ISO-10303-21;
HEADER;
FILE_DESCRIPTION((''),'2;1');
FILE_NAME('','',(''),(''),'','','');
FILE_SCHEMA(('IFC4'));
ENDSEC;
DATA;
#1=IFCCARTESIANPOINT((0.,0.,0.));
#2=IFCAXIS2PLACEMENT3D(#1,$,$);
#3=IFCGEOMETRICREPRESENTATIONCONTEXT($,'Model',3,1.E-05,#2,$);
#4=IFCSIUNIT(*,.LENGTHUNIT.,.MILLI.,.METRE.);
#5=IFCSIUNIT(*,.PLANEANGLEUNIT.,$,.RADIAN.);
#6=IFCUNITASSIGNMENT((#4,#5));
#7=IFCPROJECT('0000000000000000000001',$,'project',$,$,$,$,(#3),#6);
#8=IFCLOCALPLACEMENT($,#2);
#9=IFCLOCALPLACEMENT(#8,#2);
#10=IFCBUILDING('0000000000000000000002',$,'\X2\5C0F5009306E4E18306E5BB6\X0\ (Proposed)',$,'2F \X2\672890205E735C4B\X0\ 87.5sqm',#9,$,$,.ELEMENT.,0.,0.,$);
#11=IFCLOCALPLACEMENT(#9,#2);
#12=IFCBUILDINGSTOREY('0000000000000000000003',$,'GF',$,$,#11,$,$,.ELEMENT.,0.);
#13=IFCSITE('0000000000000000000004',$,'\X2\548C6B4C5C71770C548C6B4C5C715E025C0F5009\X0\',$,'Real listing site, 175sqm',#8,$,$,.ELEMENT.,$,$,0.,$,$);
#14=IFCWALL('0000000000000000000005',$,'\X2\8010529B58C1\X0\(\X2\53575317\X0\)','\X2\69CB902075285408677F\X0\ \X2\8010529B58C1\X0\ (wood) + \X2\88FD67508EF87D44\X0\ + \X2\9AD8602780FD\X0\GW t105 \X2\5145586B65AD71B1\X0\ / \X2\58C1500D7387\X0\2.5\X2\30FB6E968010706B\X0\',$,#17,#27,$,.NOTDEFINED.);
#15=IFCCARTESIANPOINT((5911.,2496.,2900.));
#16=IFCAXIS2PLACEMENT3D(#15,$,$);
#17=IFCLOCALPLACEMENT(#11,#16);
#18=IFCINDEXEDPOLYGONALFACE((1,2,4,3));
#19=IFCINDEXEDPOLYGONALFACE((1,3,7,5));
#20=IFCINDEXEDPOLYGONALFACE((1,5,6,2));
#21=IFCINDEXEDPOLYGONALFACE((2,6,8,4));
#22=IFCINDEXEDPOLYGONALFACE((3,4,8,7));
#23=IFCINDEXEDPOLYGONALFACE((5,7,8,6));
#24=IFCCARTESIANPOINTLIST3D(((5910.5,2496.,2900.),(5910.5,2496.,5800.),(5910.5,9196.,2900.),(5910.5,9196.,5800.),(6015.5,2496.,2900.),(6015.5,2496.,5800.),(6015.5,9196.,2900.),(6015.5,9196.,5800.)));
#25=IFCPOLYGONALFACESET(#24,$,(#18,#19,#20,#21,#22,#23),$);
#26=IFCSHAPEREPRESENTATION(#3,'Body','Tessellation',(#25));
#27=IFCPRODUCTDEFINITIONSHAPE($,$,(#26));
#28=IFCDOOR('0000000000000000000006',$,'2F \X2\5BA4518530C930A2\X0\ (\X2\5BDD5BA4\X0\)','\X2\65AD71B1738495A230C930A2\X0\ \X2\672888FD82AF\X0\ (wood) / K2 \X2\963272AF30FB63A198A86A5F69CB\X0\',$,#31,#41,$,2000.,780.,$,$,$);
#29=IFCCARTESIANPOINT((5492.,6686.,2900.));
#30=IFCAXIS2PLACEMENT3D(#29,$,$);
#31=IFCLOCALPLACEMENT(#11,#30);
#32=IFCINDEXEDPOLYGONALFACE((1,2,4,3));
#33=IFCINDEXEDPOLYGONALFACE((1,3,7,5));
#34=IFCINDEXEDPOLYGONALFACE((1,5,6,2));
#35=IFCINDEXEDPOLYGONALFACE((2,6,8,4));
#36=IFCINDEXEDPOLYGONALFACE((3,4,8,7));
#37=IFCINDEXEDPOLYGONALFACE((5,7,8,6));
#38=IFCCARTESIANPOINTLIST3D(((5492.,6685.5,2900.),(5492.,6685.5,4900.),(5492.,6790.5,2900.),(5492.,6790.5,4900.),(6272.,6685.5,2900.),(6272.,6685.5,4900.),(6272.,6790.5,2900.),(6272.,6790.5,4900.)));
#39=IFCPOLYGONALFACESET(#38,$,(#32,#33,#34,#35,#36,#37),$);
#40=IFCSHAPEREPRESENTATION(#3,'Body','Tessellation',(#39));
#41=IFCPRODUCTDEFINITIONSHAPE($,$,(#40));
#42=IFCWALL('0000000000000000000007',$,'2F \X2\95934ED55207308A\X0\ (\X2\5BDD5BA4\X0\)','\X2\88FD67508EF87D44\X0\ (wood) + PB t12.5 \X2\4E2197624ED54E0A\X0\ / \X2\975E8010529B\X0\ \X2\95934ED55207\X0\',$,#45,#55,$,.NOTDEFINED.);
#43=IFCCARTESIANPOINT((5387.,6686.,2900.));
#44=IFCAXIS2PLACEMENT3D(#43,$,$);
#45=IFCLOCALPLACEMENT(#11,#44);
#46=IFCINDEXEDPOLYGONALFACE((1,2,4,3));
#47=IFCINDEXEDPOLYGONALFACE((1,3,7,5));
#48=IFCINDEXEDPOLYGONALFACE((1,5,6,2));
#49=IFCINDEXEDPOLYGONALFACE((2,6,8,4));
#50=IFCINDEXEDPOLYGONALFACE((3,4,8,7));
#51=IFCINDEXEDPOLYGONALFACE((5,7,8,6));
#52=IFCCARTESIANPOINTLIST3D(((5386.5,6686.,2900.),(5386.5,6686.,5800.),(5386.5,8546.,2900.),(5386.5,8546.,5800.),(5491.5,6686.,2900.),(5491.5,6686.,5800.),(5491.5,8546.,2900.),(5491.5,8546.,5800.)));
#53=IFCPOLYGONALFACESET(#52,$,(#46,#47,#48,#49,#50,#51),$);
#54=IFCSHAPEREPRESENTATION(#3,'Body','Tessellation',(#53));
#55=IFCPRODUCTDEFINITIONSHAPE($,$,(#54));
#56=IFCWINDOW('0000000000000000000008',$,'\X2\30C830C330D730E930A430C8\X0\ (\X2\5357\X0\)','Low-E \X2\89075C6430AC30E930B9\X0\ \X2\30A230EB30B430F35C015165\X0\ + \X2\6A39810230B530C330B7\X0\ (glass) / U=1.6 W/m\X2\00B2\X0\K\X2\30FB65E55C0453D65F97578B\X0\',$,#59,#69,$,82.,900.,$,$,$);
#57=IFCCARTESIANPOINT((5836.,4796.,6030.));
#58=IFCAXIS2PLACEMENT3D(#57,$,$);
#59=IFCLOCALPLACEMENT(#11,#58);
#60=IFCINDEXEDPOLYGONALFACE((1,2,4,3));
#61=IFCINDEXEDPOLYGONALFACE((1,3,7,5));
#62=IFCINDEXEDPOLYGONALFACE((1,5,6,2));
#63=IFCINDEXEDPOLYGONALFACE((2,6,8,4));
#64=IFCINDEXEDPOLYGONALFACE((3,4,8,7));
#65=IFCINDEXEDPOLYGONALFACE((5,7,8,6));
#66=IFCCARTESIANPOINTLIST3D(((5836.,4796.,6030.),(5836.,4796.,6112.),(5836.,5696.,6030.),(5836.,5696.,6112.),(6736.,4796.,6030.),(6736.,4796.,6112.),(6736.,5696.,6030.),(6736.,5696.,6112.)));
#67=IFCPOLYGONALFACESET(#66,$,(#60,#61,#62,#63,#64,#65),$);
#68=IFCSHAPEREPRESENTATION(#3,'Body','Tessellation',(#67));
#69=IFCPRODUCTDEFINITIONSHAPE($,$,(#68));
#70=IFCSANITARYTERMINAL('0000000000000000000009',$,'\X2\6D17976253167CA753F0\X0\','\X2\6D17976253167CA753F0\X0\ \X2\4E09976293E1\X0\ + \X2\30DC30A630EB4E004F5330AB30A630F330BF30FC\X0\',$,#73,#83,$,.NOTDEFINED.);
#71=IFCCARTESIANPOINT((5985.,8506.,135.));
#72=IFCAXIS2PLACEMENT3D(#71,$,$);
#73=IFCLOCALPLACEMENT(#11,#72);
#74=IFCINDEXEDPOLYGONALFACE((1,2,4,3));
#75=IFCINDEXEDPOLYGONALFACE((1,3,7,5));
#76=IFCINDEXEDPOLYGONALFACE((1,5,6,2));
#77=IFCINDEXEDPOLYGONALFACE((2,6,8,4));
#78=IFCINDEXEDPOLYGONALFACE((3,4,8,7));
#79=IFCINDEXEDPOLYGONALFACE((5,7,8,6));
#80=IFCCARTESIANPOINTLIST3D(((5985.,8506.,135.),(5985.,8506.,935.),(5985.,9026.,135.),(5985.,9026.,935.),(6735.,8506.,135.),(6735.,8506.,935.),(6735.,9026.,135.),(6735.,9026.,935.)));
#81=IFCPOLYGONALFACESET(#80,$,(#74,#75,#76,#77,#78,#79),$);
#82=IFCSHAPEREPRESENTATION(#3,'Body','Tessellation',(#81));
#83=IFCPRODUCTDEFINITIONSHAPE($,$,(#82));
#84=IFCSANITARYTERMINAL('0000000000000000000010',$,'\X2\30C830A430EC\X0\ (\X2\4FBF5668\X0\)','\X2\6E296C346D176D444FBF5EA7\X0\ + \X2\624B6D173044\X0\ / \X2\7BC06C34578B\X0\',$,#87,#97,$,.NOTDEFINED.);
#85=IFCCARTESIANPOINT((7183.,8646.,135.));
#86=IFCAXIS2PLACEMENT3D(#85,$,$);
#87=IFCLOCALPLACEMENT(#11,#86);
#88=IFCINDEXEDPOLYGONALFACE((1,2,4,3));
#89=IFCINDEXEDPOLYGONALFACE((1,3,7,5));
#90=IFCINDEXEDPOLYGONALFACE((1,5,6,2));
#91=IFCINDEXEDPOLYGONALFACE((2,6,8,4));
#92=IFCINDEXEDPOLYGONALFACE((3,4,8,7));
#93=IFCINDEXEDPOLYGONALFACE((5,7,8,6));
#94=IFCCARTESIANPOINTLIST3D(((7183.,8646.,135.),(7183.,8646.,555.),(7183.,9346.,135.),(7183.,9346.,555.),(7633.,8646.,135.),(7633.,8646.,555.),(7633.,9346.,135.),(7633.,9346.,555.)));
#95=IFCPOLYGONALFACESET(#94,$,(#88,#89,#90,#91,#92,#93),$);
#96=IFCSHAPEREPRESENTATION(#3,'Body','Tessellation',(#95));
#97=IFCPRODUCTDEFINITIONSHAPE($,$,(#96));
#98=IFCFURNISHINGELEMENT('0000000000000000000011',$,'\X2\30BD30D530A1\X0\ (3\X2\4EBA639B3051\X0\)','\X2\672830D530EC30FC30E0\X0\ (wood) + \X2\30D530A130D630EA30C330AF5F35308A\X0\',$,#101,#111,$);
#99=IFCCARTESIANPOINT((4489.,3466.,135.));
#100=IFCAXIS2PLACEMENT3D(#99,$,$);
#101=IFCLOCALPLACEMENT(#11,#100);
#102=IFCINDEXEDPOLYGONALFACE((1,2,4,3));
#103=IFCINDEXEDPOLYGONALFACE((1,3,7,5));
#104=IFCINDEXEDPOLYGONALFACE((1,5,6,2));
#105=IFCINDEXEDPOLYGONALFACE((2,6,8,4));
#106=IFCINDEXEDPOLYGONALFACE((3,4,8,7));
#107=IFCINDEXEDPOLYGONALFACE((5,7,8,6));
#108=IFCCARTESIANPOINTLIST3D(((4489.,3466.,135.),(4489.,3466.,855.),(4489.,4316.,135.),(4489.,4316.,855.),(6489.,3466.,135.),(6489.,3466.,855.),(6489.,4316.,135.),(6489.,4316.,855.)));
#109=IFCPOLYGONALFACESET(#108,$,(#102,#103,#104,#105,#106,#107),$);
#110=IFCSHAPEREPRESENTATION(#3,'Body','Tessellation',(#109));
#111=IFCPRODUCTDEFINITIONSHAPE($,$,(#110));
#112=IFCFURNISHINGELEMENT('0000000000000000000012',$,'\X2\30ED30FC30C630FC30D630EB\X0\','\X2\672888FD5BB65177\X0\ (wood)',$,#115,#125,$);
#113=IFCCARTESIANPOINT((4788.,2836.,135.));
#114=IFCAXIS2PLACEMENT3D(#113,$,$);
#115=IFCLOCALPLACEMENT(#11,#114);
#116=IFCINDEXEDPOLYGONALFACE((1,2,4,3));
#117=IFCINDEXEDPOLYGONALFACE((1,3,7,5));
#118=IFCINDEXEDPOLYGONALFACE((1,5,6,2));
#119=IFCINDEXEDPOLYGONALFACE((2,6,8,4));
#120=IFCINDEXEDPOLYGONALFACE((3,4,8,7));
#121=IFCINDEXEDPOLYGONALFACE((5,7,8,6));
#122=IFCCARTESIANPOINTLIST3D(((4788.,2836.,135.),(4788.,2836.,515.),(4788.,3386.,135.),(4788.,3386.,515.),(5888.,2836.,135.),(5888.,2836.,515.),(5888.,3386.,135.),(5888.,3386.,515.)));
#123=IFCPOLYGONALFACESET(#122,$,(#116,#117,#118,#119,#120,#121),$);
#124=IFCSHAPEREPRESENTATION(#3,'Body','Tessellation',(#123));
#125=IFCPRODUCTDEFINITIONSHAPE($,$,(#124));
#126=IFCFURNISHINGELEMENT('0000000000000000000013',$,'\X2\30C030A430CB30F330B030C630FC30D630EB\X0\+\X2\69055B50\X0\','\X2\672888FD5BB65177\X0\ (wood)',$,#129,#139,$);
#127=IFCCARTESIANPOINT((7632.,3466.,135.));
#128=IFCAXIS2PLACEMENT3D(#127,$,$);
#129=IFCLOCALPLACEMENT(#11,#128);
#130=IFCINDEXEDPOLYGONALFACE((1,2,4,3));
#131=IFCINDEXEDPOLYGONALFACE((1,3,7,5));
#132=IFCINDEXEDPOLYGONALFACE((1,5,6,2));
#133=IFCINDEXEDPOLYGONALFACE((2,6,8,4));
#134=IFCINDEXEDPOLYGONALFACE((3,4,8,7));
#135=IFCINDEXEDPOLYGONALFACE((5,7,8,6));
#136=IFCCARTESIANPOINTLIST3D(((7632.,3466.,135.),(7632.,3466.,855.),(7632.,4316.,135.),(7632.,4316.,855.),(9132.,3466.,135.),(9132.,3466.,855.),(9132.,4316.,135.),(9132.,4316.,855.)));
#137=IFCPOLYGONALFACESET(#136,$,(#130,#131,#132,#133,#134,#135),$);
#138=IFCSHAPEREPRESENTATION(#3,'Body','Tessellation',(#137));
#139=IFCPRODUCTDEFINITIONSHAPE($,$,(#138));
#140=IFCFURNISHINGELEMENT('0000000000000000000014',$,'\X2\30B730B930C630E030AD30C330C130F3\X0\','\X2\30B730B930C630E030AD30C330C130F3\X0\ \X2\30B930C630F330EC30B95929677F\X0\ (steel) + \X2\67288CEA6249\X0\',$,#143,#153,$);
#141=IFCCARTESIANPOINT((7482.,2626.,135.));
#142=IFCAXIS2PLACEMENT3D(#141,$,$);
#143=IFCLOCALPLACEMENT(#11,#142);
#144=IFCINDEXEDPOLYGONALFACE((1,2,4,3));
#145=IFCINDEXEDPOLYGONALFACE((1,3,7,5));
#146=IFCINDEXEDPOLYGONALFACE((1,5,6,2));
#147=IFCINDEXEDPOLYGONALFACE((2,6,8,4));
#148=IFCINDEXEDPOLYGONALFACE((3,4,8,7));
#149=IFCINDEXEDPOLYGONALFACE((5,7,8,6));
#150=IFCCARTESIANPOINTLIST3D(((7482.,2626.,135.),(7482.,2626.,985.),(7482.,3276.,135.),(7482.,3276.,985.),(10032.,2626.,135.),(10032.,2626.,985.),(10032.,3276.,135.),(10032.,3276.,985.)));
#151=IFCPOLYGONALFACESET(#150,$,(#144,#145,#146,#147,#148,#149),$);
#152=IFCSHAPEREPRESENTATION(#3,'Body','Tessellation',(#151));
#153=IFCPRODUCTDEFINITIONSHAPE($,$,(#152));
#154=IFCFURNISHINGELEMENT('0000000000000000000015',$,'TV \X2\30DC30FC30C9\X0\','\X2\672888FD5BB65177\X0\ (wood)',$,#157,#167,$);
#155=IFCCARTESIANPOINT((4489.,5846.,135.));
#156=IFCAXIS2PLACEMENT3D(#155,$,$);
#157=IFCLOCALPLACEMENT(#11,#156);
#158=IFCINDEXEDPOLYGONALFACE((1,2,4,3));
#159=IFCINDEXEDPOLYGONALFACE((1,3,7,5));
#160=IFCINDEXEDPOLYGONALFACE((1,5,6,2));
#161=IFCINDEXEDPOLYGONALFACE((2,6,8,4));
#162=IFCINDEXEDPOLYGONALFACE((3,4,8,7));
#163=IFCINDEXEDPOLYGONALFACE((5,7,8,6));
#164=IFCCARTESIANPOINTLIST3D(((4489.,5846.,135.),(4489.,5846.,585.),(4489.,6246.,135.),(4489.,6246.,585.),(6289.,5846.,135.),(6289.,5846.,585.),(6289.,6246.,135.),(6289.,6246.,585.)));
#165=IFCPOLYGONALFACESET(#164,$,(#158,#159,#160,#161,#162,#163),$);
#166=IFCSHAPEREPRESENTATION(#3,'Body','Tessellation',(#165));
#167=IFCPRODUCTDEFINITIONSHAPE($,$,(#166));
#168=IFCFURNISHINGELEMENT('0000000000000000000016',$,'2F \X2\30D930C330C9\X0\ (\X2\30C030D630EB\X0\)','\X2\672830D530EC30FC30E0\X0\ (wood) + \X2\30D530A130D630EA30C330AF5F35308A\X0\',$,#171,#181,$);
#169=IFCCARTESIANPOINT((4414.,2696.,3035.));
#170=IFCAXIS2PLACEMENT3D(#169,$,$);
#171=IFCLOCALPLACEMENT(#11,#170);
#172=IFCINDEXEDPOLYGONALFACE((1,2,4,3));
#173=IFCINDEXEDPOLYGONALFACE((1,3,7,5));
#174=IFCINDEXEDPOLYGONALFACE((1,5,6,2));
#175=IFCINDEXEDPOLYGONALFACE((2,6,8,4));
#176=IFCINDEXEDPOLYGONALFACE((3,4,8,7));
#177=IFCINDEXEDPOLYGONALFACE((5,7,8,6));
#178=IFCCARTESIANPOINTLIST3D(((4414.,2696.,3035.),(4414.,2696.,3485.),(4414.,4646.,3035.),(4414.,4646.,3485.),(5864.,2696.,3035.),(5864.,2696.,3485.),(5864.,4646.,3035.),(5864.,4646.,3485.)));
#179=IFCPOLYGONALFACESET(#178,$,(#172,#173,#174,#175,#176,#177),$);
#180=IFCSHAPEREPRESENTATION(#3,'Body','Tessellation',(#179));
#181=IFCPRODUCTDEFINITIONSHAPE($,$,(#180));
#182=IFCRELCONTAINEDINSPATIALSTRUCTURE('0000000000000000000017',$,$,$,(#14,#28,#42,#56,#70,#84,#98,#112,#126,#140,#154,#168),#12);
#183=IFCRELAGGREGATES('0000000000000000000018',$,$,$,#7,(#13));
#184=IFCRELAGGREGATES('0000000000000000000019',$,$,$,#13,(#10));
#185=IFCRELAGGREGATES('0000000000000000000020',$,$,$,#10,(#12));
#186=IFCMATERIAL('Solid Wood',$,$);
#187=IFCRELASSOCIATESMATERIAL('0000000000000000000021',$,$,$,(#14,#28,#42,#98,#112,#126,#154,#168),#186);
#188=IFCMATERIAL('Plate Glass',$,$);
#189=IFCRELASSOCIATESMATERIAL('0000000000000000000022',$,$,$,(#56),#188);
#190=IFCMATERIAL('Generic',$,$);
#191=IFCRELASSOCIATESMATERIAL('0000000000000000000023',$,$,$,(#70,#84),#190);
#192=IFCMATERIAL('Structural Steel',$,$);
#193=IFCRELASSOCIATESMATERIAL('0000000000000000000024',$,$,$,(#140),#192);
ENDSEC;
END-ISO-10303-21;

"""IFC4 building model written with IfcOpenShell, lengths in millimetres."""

from ifc_helpers import new_model, si_unit, frame, frame_2d, origin, place, context, project, spatial, rectangle, extrude, material, element, fill, save


model = new_model("IFC4")

# Units and contexts
model_context = context("Model", 3, precision=1e-05, world=origin())
ifc_project = project(units=[si_unit("LENGTHUNIT", "METRE", prefix="MILLI"), si_unit("PLANEANGLEUNIT", "RADIAN")], contexts=[model_context])

# Site, building, storey
site_placement = place(None, origin())
site = spatial("IfcSite", under=ifc_project, at=site_placement, Name="和歌山県和歌山市小倉", ObjectType="Real listing site, 175sqm", CompositionType="ELEMENT", RefElevation=0.0)
building_placement = place(site_placement, origin())
building = spatial("IfcBuilding", under=site, at=building_placement, Name="小倉の丘の家 (Proposed)", ObjectType="2F 木造平屋 87.5sqm", CompositionType="ELEMENT", ElevationOfRefHeight=0.0, ElevationOfTerrain=0.0)
storey_placement = place(building_placement, origin())
storey = spatial("IfcBuildingStorey", under=building, at=storey_placement, Name="GF", CompositionType="ELEMENT", Elevation=0.0)

# Shared definitions
ifc_material_1 = material(Name="Solid Wood")

# Wall, opening, door
wall_1_placement = place(storey_placement, frame((5911.0, 2496.0, 2900.0)))
wall_1 = element("IfcWall", 1, at=wall_1_placement, inside=storey, material=ifc_material_1, Name="耐力壁(南北)", Description="構造用合板 耐力壁 (wood) + 製材軸組 + 高性能GW t105 充填断熱 / 壁倍率2.5・準耐火", PredefinedType="NOTDEFINED", context=model_context, shape_type="SweptSolid", body=[
    extrude(rectangle(XDim=105.0, YDim=6700.0, at=frame_2d((52.0, 3350.0))), frame((5911.0, 2496.0, 2900.0)), (0.0, 0.0, 1.0), 2900.0),
])
opening_1_placement = place(storey_placement, frame((5492.0, 6686.0, 2900.0)))
opening_1 = element("IfcOpeningElement", 2, at=opening_1_placement, cuts=wall_1, PredefinedType="NOTDEFINED", context=model_context, shape_type="SweptSolid", body=[
    extrude(rectangle(XDim=780.0, YDim=105.0, at=frame_2d((390.0, 52.0))), frame((5492.0, 6686.0, 2900.0)), (0.0, 0.0, 1.0), 2000.0),
])
door_1_placement = place(storey_placement, frame((5492.0, 6686.0, 2900.0)))
door_1 = element("IfcDoor", 3, at=door_1_placement, inside=storey, material=ifc_material_1, Name="2F 室内ドア (寝室)", Description="断熱玄関ドア 木製芯 (wood) / K2 防犯・採風機構", OverallHeight=2000.0, OverallWidth=780.0, context=model_context, shape_type="SweptSolid", body=[
    extrude(rectangle(XDim=780.0, YDim=105.0, at=frame_2d((390.0, 52.0))), frame((5492.0, 6686.0, 2900.0)), (0.0, 0.0, 1.0), 2000.0),
])
fill(opening_1, door_1)

# Wall
wall_2_placement = place(storey_placement, frame((5387.0, 6686.0, 2900.0)))
element("IfcWall", 4, at=wall_2_placement, inside=storey, material=ifc_material_1, Name="2F 間仕切り (寝室)", Description="製材軸組 (wood) + PB t12.5 両面仕上 / 非耐力 間仕切", PredefinedType="NOTDEFINED", context=model_context, shape_type="SweptSolid", body=[
    extrude(rectangle(XDim=105.0, YDim=1860.0, at=frame_2d((52.0, 930.0))), frame((5387.0, 6686.0, 2900.0)), (0.0, 0.0, 1.0), 2900.0),
])

# Window
ifc_material_2 = material(Name="Plate Glass")
window_placement = place(storey_placement, frame((5836.0, 4796.0, 6030.0)))
element("IfcWindow", 5, at=window_placement, inside=storey, material=ifc_material_2, Name="トップライト (南)", Description="Low-E 複層ガラス アルゴン封入 + 樹脂サッシ (glass) / U=1.6 W/m²K・日射取得型", OverallHeight=82.0, OverallWidth=900.0, context=model_context, shape_type="SweptSolid", body=[
    extrude(rectangle(XDim=900.0, YDim=900.0, at=frame_2d((450.0, 450.0))), frame((5836.0, 4796.0, 6030.0)), (0.0, 0.0, 1.0), 82.0),
])

# Sanitary terminals
ifc_material_3 = material(Name="Generic")
sanitary_terminal_1_placement = place(storey_placement, frame((5985.0, 8506.0, 135.0)))
element("IfcSanitaryTerminal", 6, at=sanitary_terminal_1_placement, inside=storey, material=ifc_material_3, Name="洗面化粧台", Description="洗面化粧台 三面鏡 + ボウル一体カウンター", PredefinedType="NOTDEFINED", context=model_context, shape_type="SweptSolid", body=[
    extrude(rectangle(XDim=750.0, YDim=520.0, at=frame_2d((375.0, 260.0))), frame((5985.0, 8506.0, 135.0)), (0.0, 0.0, 1.0), 800.0),
])
sanitary_terminal_2_placement = place(storey_placement, frame((7183.0, 8646.0, 135.0)))
element("IfcSanitaryTerminal", 7, at=sanitary_terminal_2_placement, inside=storey, material=ifc_material_3, Name="トイレ (便器)", Description="温水洗浄便座 + 手洗い / 節水型", PredefinedType="NOTDEFINED", context=model_context, shape_type="SweptSolid", body=[
    extrude(rectangle(XDim=450.0, YDim=700.0, at=frame_2d((225.0, 350.0))), frame((7183.0, 8646.0, 135.0)), (0.0, 0.0, 1.0), 420.0),
])

# Furnishing elements
furnishing_1_placement = place(storey_placement, frame((4489.0, 3466.0, 135.0)))
element("IfcFurnishingElement", 8, at=furnishing_1_placement, inside=storey, material=ifc_material_1, Name="ソファ (3人掛け)", Description="木フレーム (wood) + ファブリック張り", context=model_context, shape_type="SweptSolid", body=[
    extrude(rectangle(XDim=2000.0, YDim=850.0, at=frame_2d((1000.0, 425.0))), frame((4489.0, 3466.0, 135.0)), (0.0, 0.0, 1.0), 720.0),
])
furnishing_2_placement = place(storey_placement, frame((4788.0, 2836.0, 135.0)))
element("IfcFurnishingElement", 9, at=furnishing_2_placement, inside=storey, material=ifc_material_1, Name="ローテーブル", Description="木製家具 (wood)", context=model_context, shape_type="SweptSolid", body=[
    extrude(rectangle(XDim=1100.0, YDim=550.0, at=frame_2d((550.0, 275.0))), frame((4788.0, 2836.0, 135.0)), (0.0, 0.0, 1.0), 380.0),
])
furnishing_3_placement = place(storey_placement, frame((7632.0, 3466.0, 135.0)))
element("IfcFurnishingElement", 10, at=furnishing_3_placement, inside=storey, material=ifc_material_1, Name="ダイニングテーブル+椅子", Description="木製家具 (wood)", context=model_context, shape_type="SweptSolid", body=[
    extrude(rectangle(XDim=1500.0, YDim=850.0, at=frame_2d((750.0, 425.0))), frame((7632.0, 3466.0, 135.0)), (0.0, 0.0, 1.0), 720.0),
])
ifc_material_4 = material(Name="Structural Steel")
furnishing_4_placement = place(storey_placement, frame((7482.0, 2626.0, 135.0)))
element("IfcFurnishingElement", 11, at=furnishing_4_placement, inside=storey, material=ifc_material_4, Name="システムキッチン", Description="システムキッチン ステンレス天板 (steel) + 木質扉", context=model_context, shape_type="SweptSolid", body=[
    extrude(rectangle(XDim=2550.0, YDim=650.0, at=frame_2d((1275.0, 325.0))), frame((7482.0, 2626.0, 135.0)), (0.0, 0.0, 1.0), 850.0),
])
furnishing_5_placement = place(storey_placement, frame((4489.0, 5846.0, 135.0)))
element("IfcFurnishingElement", 12, at=furnishing_5_placement, inside=storey, material=ifc_material_1, Name="TV ボード", Description="木製家具 (wood)", context=model_context, shape_type="SweptSolid", body=[
    extrude(rectangle(XDim=1800.0, YDim=400.0, at=frame_2d((900.0, 200.0))), frame((4489.0, 5846.0, 135.0)), (0.0, 0.0, 1.0), 450.0),
])
furnishing_6_placement = place(storey_placement, frame((4414.0, 2696.0, 3035.0)))
element("IfcFurnishingElement", 13, at=furnishing_6_placement, inside=storey, material=ifc_material_1, Name="2F ベッド (ダブル)", Description="木フレーム (wood) + ファブリック張り", context=model_context, shape_type="SweptSolid", body=[
    extrude(rectangle(XDim=1450.0, YDim=1950.0, at=frame_2d((725.0, 975.0))), frame((4414.0, 2696.0, 3035.0)), (0.0, 0.0, 1.0), 450.0),
])

save(model, "model.ifc")
